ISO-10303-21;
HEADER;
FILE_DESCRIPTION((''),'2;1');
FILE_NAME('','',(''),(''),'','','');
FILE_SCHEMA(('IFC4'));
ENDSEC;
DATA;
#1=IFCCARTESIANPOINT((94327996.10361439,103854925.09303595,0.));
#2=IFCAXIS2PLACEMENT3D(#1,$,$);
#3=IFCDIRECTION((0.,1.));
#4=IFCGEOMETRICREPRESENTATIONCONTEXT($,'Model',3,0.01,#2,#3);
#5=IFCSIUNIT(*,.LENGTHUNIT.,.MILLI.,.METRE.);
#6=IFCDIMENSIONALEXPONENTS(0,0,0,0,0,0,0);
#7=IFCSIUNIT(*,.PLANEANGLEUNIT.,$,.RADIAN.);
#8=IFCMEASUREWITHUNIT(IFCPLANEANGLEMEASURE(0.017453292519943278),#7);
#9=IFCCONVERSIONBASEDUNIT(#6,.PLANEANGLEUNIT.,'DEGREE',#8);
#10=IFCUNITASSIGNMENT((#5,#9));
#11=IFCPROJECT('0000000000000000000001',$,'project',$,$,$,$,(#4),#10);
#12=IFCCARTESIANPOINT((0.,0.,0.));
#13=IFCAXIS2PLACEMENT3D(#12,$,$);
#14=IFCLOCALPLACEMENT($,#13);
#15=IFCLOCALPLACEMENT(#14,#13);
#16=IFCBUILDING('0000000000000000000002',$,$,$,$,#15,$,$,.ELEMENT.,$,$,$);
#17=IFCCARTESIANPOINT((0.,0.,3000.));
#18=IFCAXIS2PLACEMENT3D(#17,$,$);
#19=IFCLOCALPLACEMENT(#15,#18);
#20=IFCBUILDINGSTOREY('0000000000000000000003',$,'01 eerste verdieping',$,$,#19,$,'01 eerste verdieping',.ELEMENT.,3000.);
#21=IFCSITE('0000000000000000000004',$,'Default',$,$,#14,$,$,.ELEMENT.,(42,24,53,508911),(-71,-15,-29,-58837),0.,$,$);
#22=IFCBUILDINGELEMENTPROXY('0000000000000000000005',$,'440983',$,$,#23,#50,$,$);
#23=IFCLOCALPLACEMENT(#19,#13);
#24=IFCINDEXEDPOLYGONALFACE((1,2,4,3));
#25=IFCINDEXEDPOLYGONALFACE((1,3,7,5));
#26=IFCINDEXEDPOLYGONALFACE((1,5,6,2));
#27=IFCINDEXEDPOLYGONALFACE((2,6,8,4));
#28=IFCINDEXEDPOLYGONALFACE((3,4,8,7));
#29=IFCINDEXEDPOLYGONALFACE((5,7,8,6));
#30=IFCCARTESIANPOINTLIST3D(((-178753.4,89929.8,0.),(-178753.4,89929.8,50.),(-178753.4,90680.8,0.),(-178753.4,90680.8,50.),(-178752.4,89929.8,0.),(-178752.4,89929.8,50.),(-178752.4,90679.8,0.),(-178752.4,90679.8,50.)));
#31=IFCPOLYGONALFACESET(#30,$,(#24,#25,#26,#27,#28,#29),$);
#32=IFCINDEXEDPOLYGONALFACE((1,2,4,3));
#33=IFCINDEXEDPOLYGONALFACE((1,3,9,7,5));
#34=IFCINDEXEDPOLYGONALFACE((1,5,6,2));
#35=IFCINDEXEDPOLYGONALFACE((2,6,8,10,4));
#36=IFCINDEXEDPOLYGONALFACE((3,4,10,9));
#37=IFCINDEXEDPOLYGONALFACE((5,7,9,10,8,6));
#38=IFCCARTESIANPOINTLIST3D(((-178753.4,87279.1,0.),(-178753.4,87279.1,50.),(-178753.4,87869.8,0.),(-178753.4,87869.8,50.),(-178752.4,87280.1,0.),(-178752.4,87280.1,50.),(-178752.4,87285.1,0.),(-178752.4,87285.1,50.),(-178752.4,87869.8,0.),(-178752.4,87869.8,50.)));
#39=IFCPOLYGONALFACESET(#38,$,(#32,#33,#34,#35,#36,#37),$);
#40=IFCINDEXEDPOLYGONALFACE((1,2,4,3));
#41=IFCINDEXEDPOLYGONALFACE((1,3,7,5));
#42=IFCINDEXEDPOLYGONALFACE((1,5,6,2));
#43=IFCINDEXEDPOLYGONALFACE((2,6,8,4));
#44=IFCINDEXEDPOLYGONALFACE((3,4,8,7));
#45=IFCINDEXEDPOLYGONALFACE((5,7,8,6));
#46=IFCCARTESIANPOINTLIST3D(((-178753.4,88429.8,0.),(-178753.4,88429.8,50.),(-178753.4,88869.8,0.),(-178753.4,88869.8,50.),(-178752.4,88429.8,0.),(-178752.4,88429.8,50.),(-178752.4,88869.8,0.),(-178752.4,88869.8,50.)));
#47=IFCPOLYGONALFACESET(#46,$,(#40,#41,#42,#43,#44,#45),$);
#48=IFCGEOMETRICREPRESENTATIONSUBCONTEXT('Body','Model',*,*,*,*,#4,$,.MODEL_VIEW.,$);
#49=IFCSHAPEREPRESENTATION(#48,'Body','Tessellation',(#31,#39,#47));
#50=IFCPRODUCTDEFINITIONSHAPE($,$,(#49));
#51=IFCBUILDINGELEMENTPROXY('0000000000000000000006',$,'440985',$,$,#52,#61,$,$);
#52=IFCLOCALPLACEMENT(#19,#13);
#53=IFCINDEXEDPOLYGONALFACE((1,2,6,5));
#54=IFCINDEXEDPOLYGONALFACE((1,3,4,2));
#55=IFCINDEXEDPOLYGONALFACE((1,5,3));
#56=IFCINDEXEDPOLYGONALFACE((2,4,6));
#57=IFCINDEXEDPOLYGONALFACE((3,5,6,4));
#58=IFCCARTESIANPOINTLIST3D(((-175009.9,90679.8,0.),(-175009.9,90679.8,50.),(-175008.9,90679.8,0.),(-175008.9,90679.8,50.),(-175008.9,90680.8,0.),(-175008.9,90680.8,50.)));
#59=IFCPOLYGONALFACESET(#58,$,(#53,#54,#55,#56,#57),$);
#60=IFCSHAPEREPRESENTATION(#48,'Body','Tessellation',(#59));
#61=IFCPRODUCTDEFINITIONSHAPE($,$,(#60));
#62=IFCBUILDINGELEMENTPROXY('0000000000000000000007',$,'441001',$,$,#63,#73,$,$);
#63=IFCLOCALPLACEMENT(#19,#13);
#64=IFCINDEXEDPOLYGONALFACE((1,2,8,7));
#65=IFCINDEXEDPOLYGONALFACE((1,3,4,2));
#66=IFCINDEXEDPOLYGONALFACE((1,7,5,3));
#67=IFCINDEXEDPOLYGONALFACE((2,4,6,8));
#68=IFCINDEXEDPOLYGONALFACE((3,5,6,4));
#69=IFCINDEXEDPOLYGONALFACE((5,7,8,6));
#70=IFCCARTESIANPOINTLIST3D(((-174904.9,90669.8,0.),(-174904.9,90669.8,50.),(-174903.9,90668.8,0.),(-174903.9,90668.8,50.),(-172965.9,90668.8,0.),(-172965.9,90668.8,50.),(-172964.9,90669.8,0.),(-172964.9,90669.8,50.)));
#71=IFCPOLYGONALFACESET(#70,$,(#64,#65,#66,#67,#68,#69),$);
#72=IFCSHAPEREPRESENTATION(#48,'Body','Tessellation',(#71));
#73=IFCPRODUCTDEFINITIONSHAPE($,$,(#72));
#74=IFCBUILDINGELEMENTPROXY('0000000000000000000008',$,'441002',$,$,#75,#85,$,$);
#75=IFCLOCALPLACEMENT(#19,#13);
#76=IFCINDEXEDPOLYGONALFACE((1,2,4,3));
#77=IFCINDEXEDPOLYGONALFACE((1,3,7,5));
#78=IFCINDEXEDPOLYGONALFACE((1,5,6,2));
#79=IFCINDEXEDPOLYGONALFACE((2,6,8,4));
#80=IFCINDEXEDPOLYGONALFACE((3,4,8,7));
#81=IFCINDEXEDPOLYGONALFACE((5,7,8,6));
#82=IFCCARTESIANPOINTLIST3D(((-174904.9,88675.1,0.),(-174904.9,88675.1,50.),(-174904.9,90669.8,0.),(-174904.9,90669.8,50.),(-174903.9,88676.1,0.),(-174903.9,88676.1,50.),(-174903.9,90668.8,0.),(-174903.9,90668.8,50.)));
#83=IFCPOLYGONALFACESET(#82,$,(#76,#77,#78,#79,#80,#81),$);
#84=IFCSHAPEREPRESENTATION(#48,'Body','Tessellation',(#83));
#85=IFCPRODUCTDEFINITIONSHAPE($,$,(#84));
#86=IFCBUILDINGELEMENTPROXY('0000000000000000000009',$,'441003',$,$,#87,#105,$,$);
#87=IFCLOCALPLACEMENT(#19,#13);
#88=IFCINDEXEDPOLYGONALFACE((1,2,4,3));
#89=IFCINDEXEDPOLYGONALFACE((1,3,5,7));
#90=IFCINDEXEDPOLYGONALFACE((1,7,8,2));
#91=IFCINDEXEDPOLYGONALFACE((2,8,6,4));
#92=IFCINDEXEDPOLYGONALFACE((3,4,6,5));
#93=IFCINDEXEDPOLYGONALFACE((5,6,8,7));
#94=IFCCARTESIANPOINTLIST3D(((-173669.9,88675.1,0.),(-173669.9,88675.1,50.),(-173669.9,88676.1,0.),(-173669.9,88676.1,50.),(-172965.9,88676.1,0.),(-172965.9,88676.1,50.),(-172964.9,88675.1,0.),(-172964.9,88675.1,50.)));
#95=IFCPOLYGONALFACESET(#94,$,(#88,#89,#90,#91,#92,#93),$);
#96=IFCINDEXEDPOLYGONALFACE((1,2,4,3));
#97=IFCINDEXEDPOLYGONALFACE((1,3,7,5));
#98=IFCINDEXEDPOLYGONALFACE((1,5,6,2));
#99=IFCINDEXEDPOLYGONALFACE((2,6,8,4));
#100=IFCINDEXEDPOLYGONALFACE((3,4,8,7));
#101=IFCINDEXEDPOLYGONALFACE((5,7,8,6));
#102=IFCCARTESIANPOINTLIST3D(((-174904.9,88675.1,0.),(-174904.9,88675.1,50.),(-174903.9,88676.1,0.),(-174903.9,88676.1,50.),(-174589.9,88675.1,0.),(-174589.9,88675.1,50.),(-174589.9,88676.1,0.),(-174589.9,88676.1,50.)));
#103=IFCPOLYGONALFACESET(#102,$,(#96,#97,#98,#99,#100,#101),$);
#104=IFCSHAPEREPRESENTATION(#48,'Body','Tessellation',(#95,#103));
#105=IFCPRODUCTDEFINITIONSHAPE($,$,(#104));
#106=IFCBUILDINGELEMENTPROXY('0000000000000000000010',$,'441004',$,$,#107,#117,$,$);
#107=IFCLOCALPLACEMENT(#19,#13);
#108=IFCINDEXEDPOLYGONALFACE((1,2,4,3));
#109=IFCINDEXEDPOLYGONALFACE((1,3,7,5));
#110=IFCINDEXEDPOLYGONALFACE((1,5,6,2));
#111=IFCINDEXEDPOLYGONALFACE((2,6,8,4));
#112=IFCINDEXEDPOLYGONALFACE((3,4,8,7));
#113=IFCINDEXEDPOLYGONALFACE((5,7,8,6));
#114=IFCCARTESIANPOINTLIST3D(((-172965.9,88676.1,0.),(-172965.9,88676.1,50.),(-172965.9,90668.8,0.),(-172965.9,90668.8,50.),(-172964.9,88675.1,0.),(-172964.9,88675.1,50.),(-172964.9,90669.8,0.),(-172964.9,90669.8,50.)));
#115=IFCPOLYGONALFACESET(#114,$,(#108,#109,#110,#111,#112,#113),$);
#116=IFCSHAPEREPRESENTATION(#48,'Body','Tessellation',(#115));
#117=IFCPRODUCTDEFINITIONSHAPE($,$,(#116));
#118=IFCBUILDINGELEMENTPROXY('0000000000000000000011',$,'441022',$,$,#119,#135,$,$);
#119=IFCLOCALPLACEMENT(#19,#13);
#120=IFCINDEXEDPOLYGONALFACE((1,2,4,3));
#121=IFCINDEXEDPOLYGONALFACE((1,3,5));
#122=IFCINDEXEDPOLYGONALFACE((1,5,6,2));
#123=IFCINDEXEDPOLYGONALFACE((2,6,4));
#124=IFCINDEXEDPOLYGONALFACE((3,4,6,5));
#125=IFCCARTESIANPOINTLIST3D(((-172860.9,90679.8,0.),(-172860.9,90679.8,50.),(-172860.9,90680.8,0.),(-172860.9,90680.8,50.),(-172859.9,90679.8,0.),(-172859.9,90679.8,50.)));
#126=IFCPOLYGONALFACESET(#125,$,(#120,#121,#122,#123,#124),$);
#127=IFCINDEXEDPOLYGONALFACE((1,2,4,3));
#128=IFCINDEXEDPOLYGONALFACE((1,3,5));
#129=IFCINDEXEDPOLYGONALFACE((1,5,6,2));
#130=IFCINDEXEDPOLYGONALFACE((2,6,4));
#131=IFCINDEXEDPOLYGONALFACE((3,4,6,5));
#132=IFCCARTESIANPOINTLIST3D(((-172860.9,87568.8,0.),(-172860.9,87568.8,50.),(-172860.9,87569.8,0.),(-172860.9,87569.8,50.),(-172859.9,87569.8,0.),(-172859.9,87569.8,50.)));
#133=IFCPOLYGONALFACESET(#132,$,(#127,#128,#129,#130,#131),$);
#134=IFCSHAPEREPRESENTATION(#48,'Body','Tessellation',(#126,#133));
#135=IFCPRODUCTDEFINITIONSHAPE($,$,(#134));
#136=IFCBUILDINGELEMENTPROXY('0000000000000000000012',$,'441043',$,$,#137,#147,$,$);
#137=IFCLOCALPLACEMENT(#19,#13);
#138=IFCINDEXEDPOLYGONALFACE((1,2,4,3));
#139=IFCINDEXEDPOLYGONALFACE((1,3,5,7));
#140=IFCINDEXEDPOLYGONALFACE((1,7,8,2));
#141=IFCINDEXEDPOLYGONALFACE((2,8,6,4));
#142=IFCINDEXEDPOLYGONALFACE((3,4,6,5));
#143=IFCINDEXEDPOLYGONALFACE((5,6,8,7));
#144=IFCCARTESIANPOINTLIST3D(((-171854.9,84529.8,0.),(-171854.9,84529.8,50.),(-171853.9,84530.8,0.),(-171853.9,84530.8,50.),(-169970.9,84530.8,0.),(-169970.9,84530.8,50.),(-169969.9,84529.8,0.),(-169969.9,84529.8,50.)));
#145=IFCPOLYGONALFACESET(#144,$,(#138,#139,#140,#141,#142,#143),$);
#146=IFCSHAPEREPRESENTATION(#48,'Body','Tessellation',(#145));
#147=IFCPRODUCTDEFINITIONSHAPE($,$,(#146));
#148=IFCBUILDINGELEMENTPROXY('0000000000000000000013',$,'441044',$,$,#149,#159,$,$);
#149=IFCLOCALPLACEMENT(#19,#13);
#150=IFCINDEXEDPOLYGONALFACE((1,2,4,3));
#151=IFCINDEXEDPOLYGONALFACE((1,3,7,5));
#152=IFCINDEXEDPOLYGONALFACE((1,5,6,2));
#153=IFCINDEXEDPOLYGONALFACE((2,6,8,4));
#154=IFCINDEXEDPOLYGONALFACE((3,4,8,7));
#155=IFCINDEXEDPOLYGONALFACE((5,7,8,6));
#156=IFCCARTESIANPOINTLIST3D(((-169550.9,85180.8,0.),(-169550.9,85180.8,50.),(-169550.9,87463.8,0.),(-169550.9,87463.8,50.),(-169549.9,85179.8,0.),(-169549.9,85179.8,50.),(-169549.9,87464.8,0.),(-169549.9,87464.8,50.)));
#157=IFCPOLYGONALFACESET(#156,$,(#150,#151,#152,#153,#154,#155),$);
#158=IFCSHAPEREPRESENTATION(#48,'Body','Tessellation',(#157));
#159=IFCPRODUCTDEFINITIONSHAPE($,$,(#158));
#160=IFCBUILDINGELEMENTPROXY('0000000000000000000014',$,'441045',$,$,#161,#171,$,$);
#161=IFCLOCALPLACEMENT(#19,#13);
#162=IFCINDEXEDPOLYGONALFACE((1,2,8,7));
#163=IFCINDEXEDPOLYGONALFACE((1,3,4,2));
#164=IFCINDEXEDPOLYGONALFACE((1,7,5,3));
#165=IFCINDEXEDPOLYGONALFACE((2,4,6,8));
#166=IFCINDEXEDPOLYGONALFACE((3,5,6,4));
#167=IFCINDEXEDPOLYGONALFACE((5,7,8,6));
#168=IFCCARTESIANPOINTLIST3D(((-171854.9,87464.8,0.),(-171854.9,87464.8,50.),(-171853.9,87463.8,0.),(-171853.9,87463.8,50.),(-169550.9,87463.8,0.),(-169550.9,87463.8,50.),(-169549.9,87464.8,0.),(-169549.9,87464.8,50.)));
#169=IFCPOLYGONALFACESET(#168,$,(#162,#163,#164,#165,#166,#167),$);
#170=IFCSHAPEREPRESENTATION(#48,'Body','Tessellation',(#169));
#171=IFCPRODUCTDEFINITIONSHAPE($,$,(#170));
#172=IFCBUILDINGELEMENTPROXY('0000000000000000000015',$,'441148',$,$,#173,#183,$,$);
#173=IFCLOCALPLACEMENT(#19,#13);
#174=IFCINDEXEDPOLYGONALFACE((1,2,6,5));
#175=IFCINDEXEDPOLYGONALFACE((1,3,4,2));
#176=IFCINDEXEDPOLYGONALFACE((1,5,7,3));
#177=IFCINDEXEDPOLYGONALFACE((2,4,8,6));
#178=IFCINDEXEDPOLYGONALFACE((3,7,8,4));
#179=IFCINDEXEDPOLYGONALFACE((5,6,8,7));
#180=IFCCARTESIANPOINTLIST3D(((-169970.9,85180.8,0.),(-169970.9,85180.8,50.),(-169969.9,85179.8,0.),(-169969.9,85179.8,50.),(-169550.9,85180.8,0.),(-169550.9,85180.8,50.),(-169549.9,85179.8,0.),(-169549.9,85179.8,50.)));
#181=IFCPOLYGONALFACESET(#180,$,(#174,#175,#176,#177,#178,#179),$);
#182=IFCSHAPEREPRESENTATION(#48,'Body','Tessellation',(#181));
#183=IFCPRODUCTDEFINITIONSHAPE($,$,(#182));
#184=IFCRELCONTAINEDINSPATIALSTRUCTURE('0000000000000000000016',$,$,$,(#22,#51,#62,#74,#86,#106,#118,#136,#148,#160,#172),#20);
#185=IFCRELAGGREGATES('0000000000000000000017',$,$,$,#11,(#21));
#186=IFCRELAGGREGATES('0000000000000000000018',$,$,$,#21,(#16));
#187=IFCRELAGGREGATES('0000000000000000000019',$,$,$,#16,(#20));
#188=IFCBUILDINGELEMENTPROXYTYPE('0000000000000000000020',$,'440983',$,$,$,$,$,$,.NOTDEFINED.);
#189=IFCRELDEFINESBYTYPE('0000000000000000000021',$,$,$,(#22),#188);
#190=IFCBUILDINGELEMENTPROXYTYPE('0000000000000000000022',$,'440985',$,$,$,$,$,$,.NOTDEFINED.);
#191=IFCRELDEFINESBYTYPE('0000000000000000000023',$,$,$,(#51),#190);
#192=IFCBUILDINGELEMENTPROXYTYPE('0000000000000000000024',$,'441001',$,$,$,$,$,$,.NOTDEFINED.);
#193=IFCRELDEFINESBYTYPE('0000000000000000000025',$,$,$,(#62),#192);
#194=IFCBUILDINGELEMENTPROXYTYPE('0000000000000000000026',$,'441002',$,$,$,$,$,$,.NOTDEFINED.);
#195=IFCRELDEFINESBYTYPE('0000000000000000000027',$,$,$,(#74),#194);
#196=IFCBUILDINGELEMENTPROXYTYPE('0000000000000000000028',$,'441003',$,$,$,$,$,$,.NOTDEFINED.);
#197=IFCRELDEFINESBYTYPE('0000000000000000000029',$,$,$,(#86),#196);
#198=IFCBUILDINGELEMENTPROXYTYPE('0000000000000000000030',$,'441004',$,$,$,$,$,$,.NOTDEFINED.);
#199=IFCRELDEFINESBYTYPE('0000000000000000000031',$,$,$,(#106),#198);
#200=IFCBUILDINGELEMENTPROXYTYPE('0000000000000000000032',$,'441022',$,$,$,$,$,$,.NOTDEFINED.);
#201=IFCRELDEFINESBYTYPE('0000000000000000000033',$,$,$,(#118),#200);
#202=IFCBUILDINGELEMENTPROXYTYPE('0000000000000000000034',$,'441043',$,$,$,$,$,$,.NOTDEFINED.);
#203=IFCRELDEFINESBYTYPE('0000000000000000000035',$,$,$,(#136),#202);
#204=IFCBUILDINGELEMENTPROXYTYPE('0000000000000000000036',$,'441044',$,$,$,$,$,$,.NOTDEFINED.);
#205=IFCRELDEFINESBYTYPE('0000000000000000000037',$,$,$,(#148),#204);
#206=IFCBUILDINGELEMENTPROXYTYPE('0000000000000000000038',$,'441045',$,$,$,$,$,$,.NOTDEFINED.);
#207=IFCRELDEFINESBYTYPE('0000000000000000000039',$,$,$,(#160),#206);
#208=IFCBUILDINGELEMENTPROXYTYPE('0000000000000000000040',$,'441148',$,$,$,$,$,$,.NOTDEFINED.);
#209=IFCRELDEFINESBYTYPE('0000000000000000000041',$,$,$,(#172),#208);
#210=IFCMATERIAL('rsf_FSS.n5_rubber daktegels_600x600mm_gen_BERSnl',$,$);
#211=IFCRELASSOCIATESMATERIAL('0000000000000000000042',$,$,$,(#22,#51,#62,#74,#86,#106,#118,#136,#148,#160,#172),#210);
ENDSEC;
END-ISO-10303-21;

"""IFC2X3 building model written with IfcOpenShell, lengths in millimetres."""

from ifc_helpers import new_model, entity, si_unit, converted_unit, direction, frame, frame_2d, origin, place, context, subcontext, project, spatial, polyline, rectangle, outline, extrude, material, type_object, element, save


model = new_model("IFC2X3")

# Units and contexts
model_context = context("Model", 3, precision=0.01, world=frame((94327996.10361439, 103854925.09303595, 0.0)), true_north=direction((0.0, 1.0)))
body_context = subcontext(model_context, "Body", "Model", "MODEL_VIEW")
ifc_project = project(units=[si_unit("LENGTHUNIT", "METRE", prefix="MILLI"), converted_unit("PLANEANGLEUNIT", "DEGREE", entity("IfcPlaneAngleMeasure", 0.017453292519943278), si_unit("PLANEANGLEUNIT", "RADIAN"), dimensions=[0, 0, 0, 0, 0, 0, 0])], contexts=[model_context])

# Site, building, storey
site_placement = place(None, origin())
site = spatial("IfcSite", under=ifc_project, at=site_placement, Name="Default", CompositionType="ELEMENT", RefLatitude=(42, 24, 53, 508911), RefLongitude=(-71, -15, -29, -58837), RefElevation=0.0)
building_placement = place(site_placement, origin())
building = spatial("IfcBuilding", under=site, at=building_placement, CompositionType="ELEMENT")
storey_placement = place(building_placement, frame((0.0, 0.0, 3000.0)))
storey = spatial("IfcBuildingStorey", under=building, at=storey_placement, Name="01 eerste verdieping", LongName="01 eerste verdieping", CompositionType="ELEMENT", Elevation=3000.0)

# Building element proxies
ifc_material = material(Name="rsf_FSS.n5_rubber daktegels_600x600mm_gen_BERSnl")
building_element_proxy_type_1 = type_object("IfcBuildingElementProxyType", Name="440983", PredefinedType="NOTDEFINED")
proxy_1_placement = place(storey_placement, origin())
element("IfcBuildingElementProxy", 1, at=proxy_1_placement, inside=storey, type_object=building_element_proxy_type_1, material=ifc_material, Name="440983", context=body_context, shape_type="SweptSolid", body=[
    extrude(outline(polyline([(-375.8, -0.5), (375.3, -0.5), (375.3, 0.5), (-374.8, 0.5), (-375.8, -0.5)])), frame((-178752.9, 90305.0, 0.0), z_axis=(0.0, 0.0, 1.0), x_axis=(0.0, -1.0, 0.0)), (0.0, 0.0, 1.0), 50.0),
    extrude(outline(polyline([(-353.0, -0.6), (237.7, -0.6), (236.7, 0.4), (231.7, 0.4), (-353.0, 0.4), (-353.0, -0.6)])), frame((-178752.8, 87516.8, 0.0), z_axis=(0.0, 0.0, 1.0), x_axis=(0.0, -1.0, 0.0)), (0.0, 0.0, 1.0), 50.0),
    extrude(rectangle(XDim=440.0, YDim=1.0, at=frame_2d((0.0, 0.0), x_axis=(1.0, 0.0))), frame((-178752.9, 88649.8, 0.0), z_axis=(0.0, 0.0, 1.0), x_axis=(0.0, -1.0, 0.0)), (0.0, 0.0, 1.0), 50.0),
])
building_element_proxy_type_2 = type_object("IfcBuildingElementProxyType", Name="440985", PredefinedType="NOTDEFINED")
proxy_2_placement = place(storey_placement, origin())
element("IfcBuildingElementProxy", 2, at=proxy_2_placement, inside=storey, type_object=building_element_proxy_type_2, material=ifc_material, Name="440985", context=body_context, shape_type="SweptSolid", body=[
    extrude(outline(polyline([(-0.7, -0.3), (0.3, -0.3), (0.3, 0.7), (-0.7, -0.3)])), frame((-175009.2, 90680.1, 0.0)), (0.0, 0.0, 1.0), 50.0),
])
building_element_proxy_type_3 = type_object("IfcBuildingElementProxyType", Name="441001", PredefinedType="NOTDEFINED")
proxy_3_placement = place(storey_placement, origin())
element("IfcBuildingElementProxy", 3, at=proxy_3_placement, inside=storey, type_object=building_element_proxy_type_3, material=ifc_material, Name="441001", context=body_context, shape_type="SweptSolid", body=[
    extrude(outline(polyline([(-969.0, -0.5), (969.0, -0.5), (970.0, 0.5), (-970.0, 0.5), (-969.0, -0.5)])), frame((-173934.9, 90669.3, 0.0)), (0.0, 0.0, 1.0), 50.0),
])
building_element_proxy_type_4 = type_object("IfcBuildingElementProxyType", Name="441002", PredefinedType="NOTDEFINED")
proxy_4_placement = place(storey_placement, origin())
element("IfcBuildingElementProxy", 4, at=proxy_4_placement, inside=storey, type_object=building_element_proxy_type_4, material=ifc_material, Name="441002", context=body_context, shape_type="SweptSolid", body=[
    extrude(outline(polyline([(-996.3, -0.5), (996.3, -0.5), (997.3, 0.5), (-997.3, 0.5), (-996.3, -0.5)])), frame((-174904.4, 89672.5, 0.0), z_axis=(0.0, 0.0, 1.0), x_axis=(0.0, 1.0, 0.0)), (0.0, 0.0, 1.0), 50.0),
])
building_element_proxy_type_5 = type_object("IfcBuildingElementProxyType", Name="441003", PredefinedType="NOTDEFINED")
proxy_5_placement = place(storey_placement, origin())
element("IfcBuildingElementProxy", 5, at=proxy_5_placement, inside=storey, type_object=building_element_proxy_type_5, material=ifc_material, Name="441003", context=body_context, shape_type="SweptSolid", body=[
    extrude(outline(polyline([(-351.8, -0.5), (352.3, -0.5), (352.3, 0.5), (-352.8, 0.5), (-351.8, -0.5)])), frame((-173317.6, 88675.6, 0.0), z_axis=(0.0, 0.0, 1.0), x_axis=(-1.0, 0.0, 0.0)), (0.0, 0.0, 1.0), 50.0),
    extrude(outline(polyline([(-157.2, -0.5), (156.7, -0.5), (157.7, 0.5), (-157.2, 0.5), (-157.2, -0.5)])), frame((-174747.1, 88675.6, 0.0), z_axis=(0.0, 0.0, 1.0), x_axis=(-1.0, 0.0, 0.0)), (0.0, 0.0, 1.0), 50.0),
])
building_element_proxy_type_6 = type_object("IfcBuildingElementProxyType", Name="441004", PredefinedType="NOTDEFINED")
proxy_6_placement = place(storey_placement, origin())
element("IfcBuildingElementProxy", 6, at=proxy_6_placement, inside=storey, type_object=building_element_proxy_type_6, material=ifc_material, Name="441004", context=body_context, shape_type="SweptSolid", body=[
    extrude(outline(polyline([(-996.3, -0.5), (996.3, -0.5), (997.3, 0.5), (-997.3, 0.5), (-996.3, -0.5)])), frame((-172965.4, 89672.5, 0.0), z_axis=(0.0, 0.0, 1.0), x_axis=(0.0, -1.0, 0.0)), (0.0, 0.0, 1.0), 50.0),
])
building_element_proxy_type_7 = type_object("IfcBuildingElementProxyType", Name="441022", PredefinedType="NOTDEFINED")
proxy_7_placement = place(storey_placement, origin())
element("IfcBuildingElementProxy", 7, at=proxy_7_placement, inside=storey, type_object=building_element_proxy_type_7, material=ifc_material, Name="441022", context=body_context, shape_type="SweptSolid", body=[
    extrude(outline(polyline([(-0.7, -0.3), (0.3, -0.3), (0.3, 0.7), (-0.7, -0.3)])), frame((-172860.6, 90680.1, 0.0), z_axis=(0.0, 0.0, 1.0), x_axis=(0.0, -1.0, 0.0)), (0.0, 0.0, 1.0), 50.0),
    extrude(outline(polyline([(-0.7, -0.3), (0.3, -0.3), (0.3, 0.7), (-0.7, -0.3)])), frame((-172860.6, 87569.4, 0.0), z_axis=(0.0, 0.0, 1.0), x_axis=(-1.0, 0.0, 0.0)), (0.0, 0.0, 1.0), 50.0),
])
building_element_proxy_type_8 = type_object("IfcBuildingElementProxyType", Name="441043", PredefinedType="NOTDEFINED")
proxy_8_placement = place(storey_placement, origin())
element("IfcBuildingElementProxy", 8, at=proxy_8_placement, inside=storey, type_object=building_element_proxy_type_8, material=ifc_material, Name="441043", context=body_context, shape_type="SweptSolid", body=[
    extrude(outline(polyline([(-941.5, -0.5), (941.5, -0.5), (942.5, 0.5), (-942.5, 0.5), (-941.5, -0.5)])), frame((-170912.4, 84530.3, 0.0), z_axis=(0.0, 0.0, 1.0), x_axis=(-1.0, 0.0, 0.0)), (0.0, 0.0, 1.0), 50.0),
])
building_element_proxy_type_9 = type_object("IfcBuildingElementProxyType", Name="441044", PredefinedType="NOTDEFINED")
proxy_9_placement = place(storey_placement, origin())
element("IfcBuildingElementProxy", 9, at=proxy_9_placement, inside=storey, type_object=building_element_proxy_type_9, material=ifc_material, Name="441044", context=body_context, shape_type="SweptSolid", body=[
    extrude(outline(polyline([(-1141.5, -0.5), (1141.5, -0.5), (1142.5, 0.5), (-1142.5, 0.5), (-1141.5, -0.5)])), frame((-169550.4, 86322.3, 0.0), z_axis=(0.0, 0.0, 1.0), x_axis=(0.0, -1.0, 0.0)), (0.0, 0.0, 1.0), 50.0),
])
building_element_proxy_type_10 = type_object("IfcBuildingElementProxyType", Name="441045", PredefinedType="NOTDEFINED")
proxy_10_placement = place(storey_placement, origin())
element("IfcBuildingElementProxy", 10, at=proxy_10_placement, inside=storey, type_object=building_element_proxy_type_10, material=ifc_material, Name="441045", context=body_context, shape_type="SweptSolid", body=[
    extrude(outline(polyline([(-1151.5, -0.5), (1151.5, -0.5), (1152.5, 0.5), (-1152.5, 0.5), (-1151.5, -0.5)])), frame((-170702.4, 87464.3, 0.0)), (0.0, 0.0, 1.0), 50.0),
])
building_element_proxy_type_11 = type_object("IfcBuildingElementProxyType", Name="441148", PredefinedType="NOTDEFINED")
proxy_11_placement = place(storey_placement, origin())
element("IfcBuildingElementProxy", 11, at=proxy_11_placement, inside=storey, type_object=building_element_proxy_type_11, material=ifc_material, Name="441148", context=body_context, shape_type="SweptSolid", body=[
    extrude(outline(polyline([(-209.5, -0.5), (210.5, -0.5), (209.5, 0.5), (-210.5, 0.5), (-209.5, -0.5)])), frame((-169760.4, 85180.3, 0.0)), (0.0, 0.0, 1.0), 50.0),
])

save(model, "model.ifc")
